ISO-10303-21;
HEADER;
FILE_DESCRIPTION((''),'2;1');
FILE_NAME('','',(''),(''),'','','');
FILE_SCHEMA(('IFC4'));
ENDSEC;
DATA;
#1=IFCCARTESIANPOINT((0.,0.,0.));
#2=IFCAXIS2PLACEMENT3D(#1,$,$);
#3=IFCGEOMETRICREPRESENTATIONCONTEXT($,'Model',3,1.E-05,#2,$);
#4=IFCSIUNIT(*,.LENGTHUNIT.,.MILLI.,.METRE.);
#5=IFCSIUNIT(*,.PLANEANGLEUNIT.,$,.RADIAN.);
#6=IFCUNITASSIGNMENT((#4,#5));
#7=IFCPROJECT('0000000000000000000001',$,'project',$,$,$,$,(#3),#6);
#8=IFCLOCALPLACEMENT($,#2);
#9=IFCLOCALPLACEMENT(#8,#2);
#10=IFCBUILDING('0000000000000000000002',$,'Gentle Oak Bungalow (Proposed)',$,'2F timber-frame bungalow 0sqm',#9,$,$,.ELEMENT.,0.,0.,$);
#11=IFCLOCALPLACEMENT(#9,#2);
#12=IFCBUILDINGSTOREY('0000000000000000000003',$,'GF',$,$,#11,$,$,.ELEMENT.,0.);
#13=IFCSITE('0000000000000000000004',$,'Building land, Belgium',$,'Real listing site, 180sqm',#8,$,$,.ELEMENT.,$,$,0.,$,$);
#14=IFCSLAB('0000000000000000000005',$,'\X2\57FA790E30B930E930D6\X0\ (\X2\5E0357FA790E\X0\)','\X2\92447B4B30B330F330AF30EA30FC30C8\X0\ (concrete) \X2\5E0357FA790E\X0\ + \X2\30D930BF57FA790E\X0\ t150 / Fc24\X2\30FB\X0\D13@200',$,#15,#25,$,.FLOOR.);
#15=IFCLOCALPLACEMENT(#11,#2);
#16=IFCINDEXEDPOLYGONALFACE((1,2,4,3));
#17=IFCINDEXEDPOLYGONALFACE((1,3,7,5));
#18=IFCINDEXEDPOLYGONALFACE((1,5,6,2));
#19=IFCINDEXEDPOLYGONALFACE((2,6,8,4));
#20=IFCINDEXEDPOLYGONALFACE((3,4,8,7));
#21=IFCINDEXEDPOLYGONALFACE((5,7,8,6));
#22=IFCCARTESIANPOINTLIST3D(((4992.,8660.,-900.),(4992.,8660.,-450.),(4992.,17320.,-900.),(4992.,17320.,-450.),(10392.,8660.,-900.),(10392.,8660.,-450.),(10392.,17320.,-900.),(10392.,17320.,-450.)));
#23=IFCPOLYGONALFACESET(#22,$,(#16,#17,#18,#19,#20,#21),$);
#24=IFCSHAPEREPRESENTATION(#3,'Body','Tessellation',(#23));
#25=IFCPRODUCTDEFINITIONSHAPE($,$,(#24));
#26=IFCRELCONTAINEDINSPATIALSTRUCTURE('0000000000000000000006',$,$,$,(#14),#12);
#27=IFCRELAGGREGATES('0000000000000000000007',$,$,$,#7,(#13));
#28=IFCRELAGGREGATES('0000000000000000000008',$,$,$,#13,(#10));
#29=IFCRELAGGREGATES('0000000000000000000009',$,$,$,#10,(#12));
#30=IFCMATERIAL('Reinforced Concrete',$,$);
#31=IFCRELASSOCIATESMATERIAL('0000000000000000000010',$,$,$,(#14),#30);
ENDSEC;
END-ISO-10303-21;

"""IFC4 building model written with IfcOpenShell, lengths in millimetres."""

from ifc_helpers import new_model, si_unit, frame, frame_2d, origin, place, context, project, spatial, rectangle, extrude, material, element, save


model = new_model("IFC4")

# Units and contexts
model_context = context("Model", 3, precision=1e-05, world=origin())
ifc_project = project(units=[si_unit("LENGTHUNIT", "METRE", prefix="MILLI"), si_unit("PLANEANGLEUNIT", "RADIAN")], contexts=[model_context])

# Site, building, storey
site_placement = place(None, origin())
site = spatial("IfcSite", under=ifc_project, at=site_placement, Name="Building land, Belgium", ObjectType="Real listing site, 180sqm", CompositionType="ELEMENT", RefElevation=0.0)
building_placement = place(site_placement, origin())
building = spatial("IfcBuilding", under=site, at=building_placement, Name="Gentle Oak Bungalow (Proposed)", ObjectType="2F timber-frame bungalow 0sqm", CompositionType="ELEMENT", ElevationOfRefHeight=0.0, ElevationOfTerrain=0.0)
storey_placement = place(building_placement, origin())
storey = spatial("IfcBuildingStorey", under=building, at=storey_placement, Name="GF", CompositionType="ELEMENT", Elevation=0.0)

# Slab
ifc_material_1 = material(Name="Reinforced Concrete")
slab_1_placement = place(storey_placement, frame((2496.0, 4330.0, -450.0)))
element("IfcSlab", 1, at=slab_1_placement, inside=storey, material=ifc_material_1, Name="基礎スラブ (布基礎)", Description="鉄筋コンクリート (concrete) 布基礎 + ベタ基礎 t150 / Fc24・D13@200", PredefinedType="FLOOR", context=model_context, shape_type="SweptSolid", body=[
    extrude(rectangle(XDim=5400.0, YDim=8660.0, at=frame_2d((2700.0, 4330.0))), frame((2496.0, 4330.0, -450.0)), (0.0, 0.0, 1.0), 450.0),
])

save(model, "model.ifc")
